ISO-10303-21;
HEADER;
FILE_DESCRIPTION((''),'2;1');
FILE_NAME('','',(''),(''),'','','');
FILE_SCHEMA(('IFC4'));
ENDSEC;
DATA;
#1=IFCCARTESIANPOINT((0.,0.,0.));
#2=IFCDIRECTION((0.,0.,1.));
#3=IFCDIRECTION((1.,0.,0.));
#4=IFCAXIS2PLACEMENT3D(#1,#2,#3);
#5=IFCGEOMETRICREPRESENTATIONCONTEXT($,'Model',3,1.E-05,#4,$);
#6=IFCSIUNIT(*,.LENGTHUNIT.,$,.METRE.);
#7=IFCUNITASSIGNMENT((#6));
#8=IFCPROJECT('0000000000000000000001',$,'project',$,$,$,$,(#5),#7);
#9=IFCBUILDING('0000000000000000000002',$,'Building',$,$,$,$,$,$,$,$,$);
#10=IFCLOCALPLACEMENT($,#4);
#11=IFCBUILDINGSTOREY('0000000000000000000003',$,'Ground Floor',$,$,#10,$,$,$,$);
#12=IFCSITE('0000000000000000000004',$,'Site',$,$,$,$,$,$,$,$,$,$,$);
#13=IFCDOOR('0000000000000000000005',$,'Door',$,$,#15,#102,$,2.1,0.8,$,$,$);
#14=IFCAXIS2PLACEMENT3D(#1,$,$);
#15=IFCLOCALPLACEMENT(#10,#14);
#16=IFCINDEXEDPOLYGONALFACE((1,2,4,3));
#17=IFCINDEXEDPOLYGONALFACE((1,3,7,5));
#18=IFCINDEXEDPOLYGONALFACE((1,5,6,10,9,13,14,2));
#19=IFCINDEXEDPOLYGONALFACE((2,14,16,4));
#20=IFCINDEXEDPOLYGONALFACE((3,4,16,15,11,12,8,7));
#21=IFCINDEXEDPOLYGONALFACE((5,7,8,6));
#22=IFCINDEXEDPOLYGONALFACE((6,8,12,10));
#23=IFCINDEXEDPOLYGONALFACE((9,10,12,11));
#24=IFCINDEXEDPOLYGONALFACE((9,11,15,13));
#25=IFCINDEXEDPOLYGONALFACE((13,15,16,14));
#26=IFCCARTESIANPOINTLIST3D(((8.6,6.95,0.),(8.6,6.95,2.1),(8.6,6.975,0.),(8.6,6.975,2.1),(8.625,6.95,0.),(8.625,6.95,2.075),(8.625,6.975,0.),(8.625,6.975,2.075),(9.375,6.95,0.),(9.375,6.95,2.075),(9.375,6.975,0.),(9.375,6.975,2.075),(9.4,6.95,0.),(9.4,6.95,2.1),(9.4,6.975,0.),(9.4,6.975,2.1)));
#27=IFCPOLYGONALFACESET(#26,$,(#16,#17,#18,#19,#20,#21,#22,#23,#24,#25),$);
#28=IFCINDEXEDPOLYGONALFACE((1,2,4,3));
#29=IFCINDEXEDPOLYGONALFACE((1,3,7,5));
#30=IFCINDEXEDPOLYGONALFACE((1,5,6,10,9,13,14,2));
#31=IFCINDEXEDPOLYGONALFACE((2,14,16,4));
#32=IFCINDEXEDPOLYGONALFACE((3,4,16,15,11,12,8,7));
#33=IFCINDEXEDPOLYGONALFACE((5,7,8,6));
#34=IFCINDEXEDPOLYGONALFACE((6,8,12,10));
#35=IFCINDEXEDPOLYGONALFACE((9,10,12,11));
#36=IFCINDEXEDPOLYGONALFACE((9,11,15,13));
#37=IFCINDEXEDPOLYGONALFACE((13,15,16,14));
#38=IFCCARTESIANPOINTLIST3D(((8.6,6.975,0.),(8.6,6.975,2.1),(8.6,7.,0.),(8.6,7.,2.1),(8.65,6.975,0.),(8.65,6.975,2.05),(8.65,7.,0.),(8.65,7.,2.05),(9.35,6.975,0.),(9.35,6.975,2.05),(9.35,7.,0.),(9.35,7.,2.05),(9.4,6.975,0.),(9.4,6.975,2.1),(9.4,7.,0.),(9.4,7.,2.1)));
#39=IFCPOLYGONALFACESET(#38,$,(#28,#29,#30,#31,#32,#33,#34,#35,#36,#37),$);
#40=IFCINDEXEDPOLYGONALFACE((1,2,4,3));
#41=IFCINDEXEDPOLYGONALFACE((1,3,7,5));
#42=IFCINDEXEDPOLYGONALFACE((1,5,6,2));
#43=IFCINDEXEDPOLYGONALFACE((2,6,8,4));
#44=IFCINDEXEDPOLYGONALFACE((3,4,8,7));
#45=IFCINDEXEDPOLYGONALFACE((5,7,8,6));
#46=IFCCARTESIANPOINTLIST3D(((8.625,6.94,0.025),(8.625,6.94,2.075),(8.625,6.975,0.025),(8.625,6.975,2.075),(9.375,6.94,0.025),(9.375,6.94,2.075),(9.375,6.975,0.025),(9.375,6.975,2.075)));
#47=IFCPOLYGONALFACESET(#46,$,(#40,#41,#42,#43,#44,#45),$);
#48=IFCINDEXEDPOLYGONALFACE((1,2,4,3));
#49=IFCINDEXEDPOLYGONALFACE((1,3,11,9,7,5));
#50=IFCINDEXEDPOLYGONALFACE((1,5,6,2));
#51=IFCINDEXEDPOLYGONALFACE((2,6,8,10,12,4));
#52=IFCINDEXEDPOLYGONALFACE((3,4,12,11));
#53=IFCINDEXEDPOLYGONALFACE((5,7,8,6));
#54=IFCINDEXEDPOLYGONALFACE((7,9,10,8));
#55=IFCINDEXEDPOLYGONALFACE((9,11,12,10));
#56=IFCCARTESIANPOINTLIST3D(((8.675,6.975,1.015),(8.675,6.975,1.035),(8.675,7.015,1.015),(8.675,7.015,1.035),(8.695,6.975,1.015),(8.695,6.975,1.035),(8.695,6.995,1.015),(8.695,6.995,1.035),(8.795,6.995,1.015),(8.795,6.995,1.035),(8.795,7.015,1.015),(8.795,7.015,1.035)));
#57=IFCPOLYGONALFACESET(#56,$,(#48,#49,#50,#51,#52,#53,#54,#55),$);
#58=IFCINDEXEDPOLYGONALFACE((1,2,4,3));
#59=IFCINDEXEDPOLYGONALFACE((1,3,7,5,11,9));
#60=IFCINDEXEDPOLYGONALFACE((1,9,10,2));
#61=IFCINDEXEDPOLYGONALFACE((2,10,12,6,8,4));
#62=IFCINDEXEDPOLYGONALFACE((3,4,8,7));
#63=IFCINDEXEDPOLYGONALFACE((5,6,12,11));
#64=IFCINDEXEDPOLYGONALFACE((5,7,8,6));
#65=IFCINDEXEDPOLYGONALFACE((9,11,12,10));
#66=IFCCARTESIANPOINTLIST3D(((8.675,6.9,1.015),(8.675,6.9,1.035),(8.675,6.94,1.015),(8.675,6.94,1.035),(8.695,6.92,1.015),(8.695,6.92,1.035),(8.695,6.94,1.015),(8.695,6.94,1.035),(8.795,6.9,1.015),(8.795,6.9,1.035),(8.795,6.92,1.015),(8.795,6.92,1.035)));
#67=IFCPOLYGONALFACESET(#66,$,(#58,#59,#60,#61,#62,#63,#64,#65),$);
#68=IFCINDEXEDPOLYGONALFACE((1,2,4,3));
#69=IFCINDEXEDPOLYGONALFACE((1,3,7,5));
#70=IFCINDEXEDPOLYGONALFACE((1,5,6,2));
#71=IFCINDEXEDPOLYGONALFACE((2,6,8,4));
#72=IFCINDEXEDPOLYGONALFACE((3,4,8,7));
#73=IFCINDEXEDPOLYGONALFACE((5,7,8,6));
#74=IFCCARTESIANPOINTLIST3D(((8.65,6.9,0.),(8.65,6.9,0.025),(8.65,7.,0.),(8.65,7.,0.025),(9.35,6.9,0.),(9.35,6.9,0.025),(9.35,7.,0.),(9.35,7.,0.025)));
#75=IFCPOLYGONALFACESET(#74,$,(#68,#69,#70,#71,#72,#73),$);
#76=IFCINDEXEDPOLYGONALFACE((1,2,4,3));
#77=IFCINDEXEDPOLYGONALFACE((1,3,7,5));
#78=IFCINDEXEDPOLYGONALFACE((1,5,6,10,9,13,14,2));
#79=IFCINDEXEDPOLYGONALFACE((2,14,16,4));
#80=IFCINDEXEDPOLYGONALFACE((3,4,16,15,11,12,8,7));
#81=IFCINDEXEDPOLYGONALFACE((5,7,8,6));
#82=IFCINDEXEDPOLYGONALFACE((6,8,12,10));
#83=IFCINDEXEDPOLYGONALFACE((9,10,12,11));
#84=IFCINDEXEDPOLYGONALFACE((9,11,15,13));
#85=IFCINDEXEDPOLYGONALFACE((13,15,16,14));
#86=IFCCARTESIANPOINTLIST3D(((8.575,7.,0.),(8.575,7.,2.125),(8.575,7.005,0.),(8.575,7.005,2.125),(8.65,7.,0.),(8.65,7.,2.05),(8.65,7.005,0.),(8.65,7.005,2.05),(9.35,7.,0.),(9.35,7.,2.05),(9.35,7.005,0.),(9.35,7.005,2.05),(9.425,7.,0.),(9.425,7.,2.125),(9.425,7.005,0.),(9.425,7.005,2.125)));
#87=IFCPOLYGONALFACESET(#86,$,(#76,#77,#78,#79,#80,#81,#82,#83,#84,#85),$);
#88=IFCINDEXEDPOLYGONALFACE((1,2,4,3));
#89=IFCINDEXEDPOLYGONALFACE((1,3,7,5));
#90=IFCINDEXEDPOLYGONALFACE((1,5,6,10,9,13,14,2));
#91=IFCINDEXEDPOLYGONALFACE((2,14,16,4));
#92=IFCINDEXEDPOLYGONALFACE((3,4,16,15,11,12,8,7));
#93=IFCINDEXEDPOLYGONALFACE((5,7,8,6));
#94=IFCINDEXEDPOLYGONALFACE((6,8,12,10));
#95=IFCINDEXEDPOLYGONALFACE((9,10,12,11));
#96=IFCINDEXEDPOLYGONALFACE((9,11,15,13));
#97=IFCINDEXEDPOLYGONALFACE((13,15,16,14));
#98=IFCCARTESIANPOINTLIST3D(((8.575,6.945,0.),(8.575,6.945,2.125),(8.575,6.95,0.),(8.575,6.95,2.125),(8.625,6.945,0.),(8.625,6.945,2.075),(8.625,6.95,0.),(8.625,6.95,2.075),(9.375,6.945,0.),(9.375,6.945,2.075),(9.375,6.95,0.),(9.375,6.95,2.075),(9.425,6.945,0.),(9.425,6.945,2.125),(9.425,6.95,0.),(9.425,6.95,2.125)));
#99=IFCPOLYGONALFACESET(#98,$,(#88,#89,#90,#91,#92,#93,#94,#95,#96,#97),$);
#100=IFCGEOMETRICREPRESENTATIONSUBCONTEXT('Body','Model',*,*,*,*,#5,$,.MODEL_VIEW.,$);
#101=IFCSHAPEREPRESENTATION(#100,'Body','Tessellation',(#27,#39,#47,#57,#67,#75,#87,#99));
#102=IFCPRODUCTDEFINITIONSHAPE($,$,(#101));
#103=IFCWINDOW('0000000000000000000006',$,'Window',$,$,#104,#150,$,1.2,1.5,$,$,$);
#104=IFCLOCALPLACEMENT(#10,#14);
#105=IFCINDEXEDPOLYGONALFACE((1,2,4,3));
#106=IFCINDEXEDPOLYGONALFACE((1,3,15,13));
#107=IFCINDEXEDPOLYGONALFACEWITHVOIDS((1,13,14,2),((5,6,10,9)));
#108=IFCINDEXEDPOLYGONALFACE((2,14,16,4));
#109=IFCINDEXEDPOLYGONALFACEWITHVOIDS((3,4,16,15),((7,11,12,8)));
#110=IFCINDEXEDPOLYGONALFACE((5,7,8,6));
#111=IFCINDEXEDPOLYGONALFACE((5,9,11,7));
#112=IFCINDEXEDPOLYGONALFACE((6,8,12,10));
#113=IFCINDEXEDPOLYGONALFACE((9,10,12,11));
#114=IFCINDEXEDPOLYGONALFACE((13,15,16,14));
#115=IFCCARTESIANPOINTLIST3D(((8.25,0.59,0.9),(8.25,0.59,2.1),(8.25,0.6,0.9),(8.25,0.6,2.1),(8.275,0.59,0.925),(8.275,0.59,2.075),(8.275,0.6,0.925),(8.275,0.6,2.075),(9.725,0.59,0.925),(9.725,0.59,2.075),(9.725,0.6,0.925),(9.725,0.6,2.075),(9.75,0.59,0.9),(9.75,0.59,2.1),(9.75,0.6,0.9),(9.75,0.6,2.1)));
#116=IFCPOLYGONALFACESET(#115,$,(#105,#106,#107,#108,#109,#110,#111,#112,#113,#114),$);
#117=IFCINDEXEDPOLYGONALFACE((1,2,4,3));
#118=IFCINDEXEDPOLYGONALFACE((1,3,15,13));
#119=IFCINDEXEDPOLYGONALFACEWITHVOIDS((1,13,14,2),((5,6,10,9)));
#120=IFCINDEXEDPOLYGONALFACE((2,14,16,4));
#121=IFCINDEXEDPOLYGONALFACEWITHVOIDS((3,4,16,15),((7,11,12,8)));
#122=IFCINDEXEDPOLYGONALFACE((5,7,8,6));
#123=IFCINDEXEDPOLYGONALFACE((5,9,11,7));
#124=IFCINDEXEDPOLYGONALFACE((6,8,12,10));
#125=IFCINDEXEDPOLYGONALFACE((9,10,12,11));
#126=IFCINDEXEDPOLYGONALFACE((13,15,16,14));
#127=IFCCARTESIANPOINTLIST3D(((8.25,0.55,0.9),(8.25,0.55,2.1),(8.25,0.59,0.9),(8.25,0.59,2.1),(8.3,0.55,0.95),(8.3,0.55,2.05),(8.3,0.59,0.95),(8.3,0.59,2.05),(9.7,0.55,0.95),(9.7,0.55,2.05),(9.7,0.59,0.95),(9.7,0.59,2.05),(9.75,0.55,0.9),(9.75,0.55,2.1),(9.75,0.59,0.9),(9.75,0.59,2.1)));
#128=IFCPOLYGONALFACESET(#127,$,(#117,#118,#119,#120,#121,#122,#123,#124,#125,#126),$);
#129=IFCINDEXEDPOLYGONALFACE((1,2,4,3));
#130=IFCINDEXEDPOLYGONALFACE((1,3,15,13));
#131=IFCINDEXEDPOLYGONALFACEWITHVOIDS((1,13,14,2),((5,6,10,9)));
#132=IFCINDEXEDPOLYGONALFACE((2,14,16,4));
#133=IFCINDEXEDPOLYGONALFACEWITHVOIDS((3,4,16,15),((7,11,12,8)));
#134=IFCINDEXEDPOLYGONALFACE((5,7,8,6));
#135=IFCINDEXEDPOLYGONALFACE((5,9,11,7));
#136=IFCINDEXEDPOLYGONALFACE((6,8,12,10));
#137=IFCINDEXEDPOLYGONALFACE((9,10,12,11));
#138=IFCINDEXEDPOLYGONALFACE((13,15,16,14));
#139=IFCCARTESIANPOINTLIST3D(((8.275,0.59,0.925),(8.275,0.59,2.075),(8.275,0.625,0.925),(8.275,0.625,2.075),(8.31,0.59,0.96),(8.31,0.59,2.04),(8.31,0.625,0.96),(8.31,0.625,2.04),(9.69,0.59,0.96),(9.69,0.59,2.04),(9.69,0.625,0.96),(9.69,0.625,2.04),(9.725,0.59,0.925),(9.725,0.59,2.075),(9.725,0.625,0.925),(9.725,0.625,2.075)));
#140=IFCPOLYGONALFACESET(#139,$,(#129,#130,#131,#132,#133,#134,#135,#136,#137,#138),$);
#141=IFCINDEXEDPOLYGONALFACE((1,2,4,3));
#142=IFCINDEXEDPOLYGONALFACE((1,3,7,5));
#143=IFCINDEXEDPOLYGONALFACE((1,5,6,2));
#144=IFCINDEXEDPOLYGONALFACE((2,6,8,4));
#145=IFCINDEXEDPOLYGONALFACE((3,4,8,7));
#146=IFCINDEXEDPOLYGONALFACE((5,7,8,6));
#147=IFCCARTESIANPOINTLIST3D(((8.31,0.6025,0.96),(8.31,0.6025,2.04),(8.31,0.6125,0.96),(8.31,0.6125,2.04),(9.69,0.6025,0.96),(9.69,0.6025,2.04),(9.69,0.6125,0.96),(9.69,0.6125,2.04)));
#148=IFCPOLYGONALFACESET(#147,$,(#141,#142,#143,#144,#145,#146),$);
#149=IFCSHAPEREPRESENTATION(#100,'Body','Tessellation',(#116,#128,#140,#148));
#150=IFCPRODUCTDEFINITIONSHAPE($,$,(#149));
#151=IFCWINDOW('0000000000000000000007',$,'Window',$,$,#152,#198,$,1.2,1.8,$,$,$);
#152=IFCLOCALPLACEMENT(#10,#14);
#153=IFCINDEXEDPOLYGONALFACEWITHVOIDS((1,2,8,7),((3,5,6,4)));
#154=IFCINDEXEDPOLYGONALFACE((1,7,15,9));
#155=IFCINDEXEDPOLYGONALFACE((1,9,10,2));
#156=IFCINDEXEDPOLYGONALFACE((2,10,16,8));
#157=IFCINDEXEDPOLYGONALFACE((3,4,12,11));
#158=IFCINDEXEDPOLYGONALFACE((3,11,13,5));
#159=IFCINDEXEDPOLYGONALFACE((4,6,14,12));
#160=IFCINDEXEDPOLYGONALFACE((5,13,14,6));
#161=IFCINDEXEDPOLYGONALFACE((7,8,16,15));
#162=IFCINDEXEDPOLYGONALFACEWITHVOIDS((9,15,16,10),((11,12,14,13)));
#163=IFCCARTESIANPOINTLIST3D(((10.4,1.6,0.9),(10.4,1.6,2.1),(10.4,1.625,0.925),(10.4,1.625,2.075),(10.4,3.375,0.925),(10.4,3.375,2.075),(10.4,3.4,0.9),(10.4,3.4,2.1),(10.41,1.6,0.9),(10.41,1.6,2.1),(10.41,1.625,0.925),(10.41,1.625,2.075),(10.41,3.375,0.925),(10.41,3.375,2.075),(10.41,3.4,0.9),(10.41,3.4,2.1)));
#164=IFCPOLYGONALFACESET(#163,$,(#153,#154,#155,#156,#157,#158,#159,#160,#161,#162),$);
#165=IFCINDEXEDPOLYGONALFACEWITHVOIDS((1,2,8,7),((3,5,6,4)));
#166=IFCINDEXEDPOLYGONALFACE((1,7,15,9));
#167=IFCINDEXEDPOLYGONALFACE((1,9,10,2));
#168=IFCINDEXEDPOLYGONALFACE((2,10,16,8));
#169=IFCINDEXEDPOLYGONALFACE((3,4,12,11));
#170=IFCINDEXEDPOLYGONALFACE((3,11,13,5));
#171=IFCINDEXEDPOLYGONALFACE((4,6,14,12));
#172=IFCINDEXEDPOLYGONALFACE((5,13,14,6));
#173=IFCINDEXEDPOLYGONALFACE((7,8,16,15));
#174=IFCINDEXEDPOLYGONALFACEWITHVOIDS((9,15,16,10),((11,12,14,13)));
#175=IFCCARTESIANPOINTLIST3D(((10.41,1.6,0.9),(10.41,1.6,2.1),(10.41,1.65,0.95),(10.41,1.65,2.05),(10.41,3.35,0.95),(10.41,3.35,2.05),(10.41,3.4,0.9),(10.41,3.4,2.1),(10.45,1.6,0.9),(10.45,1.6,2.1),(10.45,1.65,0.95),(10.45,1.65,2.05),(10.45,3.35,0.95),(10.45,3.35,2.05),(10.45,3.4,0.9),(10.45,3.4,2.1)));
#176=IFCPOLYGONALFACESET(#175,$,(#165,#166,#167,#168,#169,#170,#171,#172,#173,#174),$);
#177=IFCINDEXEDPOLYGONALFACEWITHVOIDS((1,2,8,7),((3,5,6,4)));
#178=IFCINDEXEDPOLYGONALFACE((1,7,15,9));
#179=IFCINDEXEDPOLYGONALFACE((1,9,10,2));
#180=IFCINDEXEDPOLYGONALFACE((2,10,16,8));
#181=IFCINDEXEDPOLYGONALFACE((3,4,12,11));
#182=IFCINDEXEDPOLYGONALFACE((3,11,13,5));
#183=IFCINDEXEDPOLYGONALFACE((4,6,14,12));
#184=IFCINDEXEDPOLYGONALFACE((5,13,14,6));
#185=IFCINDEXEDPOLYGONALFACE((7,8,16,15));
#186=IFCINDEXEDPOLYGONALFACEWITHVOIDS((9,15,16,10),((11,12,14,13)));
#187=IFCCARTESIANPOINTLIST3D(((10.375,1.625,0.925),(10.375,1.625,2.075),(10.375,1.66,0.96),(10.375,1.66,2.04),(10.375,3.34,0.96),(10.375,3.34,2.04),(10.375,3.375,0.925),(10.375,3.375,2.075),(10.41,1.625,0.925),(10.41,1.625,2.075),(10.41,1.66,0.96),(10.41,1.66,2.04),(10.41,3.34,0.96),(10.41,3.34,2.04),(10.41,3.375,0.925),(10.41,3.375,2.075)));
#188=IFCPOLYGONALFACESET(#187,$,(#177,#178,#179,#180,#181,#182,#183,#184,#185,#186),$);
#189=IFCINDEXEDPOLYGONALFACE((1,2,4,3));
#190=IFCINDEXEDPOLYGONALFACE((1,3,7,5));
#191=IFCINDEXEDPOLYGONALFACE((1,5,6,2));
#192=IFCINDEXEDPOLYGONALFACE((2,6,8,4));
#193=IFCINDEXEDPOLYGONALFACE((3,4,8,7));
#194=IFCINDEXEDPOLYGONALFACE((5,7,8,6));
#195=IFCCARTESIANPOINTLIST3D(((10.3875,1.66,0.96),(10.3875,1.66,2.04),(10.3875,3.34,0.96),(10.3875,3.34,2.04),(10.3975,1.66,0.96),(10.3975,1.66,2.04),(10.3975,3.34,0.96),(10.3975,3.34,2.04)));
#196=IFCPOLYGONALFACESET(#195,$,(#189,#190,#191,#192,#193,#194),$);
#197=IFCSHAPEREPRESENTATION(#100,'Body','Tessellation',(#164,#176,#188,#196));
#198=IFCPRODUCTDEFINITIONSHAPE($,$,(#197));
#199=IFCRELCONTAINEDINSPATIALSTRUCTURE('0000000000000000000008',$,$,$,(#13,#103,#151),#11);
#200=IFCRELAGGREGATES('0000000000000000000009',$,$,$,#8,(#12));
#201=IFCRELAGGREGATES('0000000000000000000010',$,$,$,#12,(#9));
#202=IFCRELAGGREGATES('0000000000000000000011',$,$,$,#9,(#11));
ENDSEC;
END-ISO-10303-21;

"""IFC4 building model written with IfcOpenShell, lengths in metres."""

from ifc_helpers import new_model, si_unit, frame, origin_with_axes, place, context, subcontext, project, spatial, line, indexed_curve, outline, extrude, element, save


model = new_model("IFC4")

# Units and contexts
model_context = context("Model", 3, precision=1e-05, world=origin_with_axes())
body_context = subcontext(model_context, "Body", "Model", "MODEL_VIEW")
ifc_project = project(units=[si_unit("LENGTHUNIT", "METRE")], contexts=[model_context])

# Site, building, storey
site = spatial("IfcSite", under=ifc_project, Name="Site")
building = spatial("IfcBuilding", under=site, Name="Building")
storey_placement = place(None, origin_with_axes())
storey = spatial("IfcBuildingStorey", under=building, at=storey_placement, Name="Ground Floor")

# Door
door_1_placement = place(storey_placement, frame((9.4, 7.0, 0.0), z_axis=(0.0, 0.0, 1.0), x_axis=(-1.0, 0.0, 0.0)))
element("IfcDoor", 1, at=door_1_placement, inside=storey, Name="Door", OverallHeight=2.1, OverallWidth=0.8, context=body_context, shape_type="SweptSolid", body=[
    extrude(outline(indexed_curve([(0.0, 0.0), (0.0, 2.1), (0.8, 2.1), (0.8, 0.0), (0.775, 0.0), (0.775, 2.075), (0.025, 2.075), (0.025, 0.0)], segments=[line(1, 2, 3, 4, 5, 6, 7, 8, 1)])), frame((0.0, 0.025, 0.0), z_axis=(0.0, -1.0, 0.0), x_axis=(1.0, 0.0, 0.0)), (0.0, 0.0, -1.0), 0.025),
    extrude(outline(indexed_curve([(0.0, 0.0), (0.0, 2.1), (0.8, 2.1), (0.8, 0.0), (0.75, 0.0), (0.75, 2.05), (0.05, 2.05), (0.05, 0.0)], segments=[line(1, 2, 3, 4, 5, 6, 7, 8, 1)])), frame((0.0, 0.0, 0.0), z_axis=(0.0, -1.0, 0.0), x_axis=(1.0, 0.0, 0.0)), (0.0, 0.0, -1.0), 0.025),
    extrude(outline(indexed_curve([(0.0, 0.0), (0.75, 0.0), (0.75, 0.035), (0.0, 0.035)], segments=[line(1, 2, 3, 4, 1)])), frame((0.025, 0.025, 0.025), z_axis=(0.0, 0.0, 1.0), x_axis=(1.0, 0.0, 0.0)), (0.0, 0.0, 1.0), 2.05),
    extrude(outline(indexed_curve([(0.0, 0.0), (0.0, -0.04), (-0.12, -0.04), (-0.12, -0.02), (-0.02, -0.02), (-0.02, 0.0)], segments=[line(1, 2, 3, 4, 5, 6, 1)])), frame((0.725, 0.025, 1.015), z_axis=(0.0, 0.0, 1.0), x_axis=(1.0, 0.0, 0.0)), (0.0, 0.0, 1.0), 0.02),
    extrude(outline(indexed_curve([(0.0, 0.0), (0.0, 0.04), (-0.12, 0.04), (-0.12, 0.02), (-0.02, 0.02), (-0.02, 0.0)], segments=[line(1, 2, 3, 4, 5, 6, 1)])), frame((0.725, 0.06, 1.015), z_axis=(0.0, 0.0, 1.0), x_axis=(1.0, 0.0, 0.0)), (0.0, 0.0, 1.0), 0.02),
    extrude(outline(indexed_curve([(0.0, 0.0), (0.7, 0.0), (0.7, 0.1), (0.0, 0.1)], segments=[line(1, 2, 3, 4, 1)])), frame((0.05, 0.0, 0.0), z_axis=(0.0, 0.0, 1.0), x_axis=(1.0, 0.0, 0.0)), (0.0, 0.0, 1.0), 0.025),
    extrude(outline(indexed_curve([(0.0, 0.0), (0.0, 2.125), (0.85, 2.125), (0.85, 0.0), (0.775, 0.0), (0.775, 2.05), (0.075, 2.05), (0.075, 0.0)], segments=[line(1, 2, 3, 4, 5, 6, 7, 8, 1)])), frame((-0.025, -0.005, 0.0), z_axis=(0.0, -1.0, 0.0), x_axis=(1.0, 0.0, 0.0)), (0.0, 0.0, -1.0), 0.005),
    extrude(outline(indexed_curve([(0.0, 0.0), (0.0, 2.125), (0.85, 2.125), (0.85, 0.0), (0.8, 0.0), (0.8, 2.075), (0.05, 2.075), (0.05, 0.0)], segments=[line(1, 2, 3, 4, 5, 6, 7, 8, 1)])), frame((-0.025, 0.05, 0.0), z_axis=(0.0, -1.0, 0.0), x_axis=(1.0, 0.0, 0.0)), (0.0, 0.0, -1.0), 0.005),
])

# Windows
window_1_placement = place(storey_placement, frame((8.25, 0.5, 0.9), z_axis=(0.0, 0.0, 1.0), x_axis=(1.0, 0.0, 0.0)))
element("IfcWindow", 2, at=window_1_placement, inside=storey, Name="Window", OverallHeight=1.2, OverallWidth=1.5, context=body_context, shape_type="SweptSolid", body=[
    extrude(outline(indexed_curve([(0.0, 0.0), (1.5, 0.0), (1.5, 1.2), (0.0, 1.2)], segments=[line(1, 2, 3, 4, 1)]), holes=[indexed_curve([(0.025, 0.025), (1.475, 0.025), (1.475, 1.175), (0.025, 1.175)], segments=[line(1, 2, 3, 4, 1)])]), frame((0.0, 0.09, 0.0), z_axis=(0.0, -1.0, 0.0), x_axis=(1.0, 0.0, 0.0)), (0.0, 0.0, -1.0), 0.01),
    extrude(outline(indexed_curve([(0.0, 0.0), (1.5, 0.0), (1.5, 1.2), (0.0, 1.2)], segments=[line(1, 2, 3, 4, 1)]), holes=[indexed_curve([(0.05, 0.05), (1.45, 0.05), (1.45, 1.15), (0.05, 1.15)], segments=[line(1, 2, 3, 4, 1)])]), frame((0.0, 0.05, 0.0), z_axis=(0.0, -1.0, 0.0), x_axis=(1.0, 0.0, 0.0)), (0.0, 0.0, -1.0), 0.04),
    extrude(outline(indexed_curve([(0.0, 0.0), (1.45, 0.0), (1.45, 1.15), (0.0, 1.15)], segments=[line(1, 2, 3, 4, 1)]), holes=[indexed_curve([(0.035, 0.035), (1.415, 0.035), (1.415, 1.115), (0.035, 1.115)], segments=[line(1, 2, 3, 4, 1)])]), frame((0.025, 0.09, 0.025), z_axis=(0.0, -1.0, 0.0), x_axis=(1.0, 0.0, 0.0)), (0.0, 0.0, -1.0), 0.035),
    extrude(outline(indexed_curve([(0.035, 0.035), (1.415, 0.035), (1.415, 1.115), (0.035, 1.115)], segments=[line(1, 2, 3, 4, 1)])), frame((0.025, 0.1025, 0.025), z_axis=(0.0, -1.0, 0.0), x_axis=(1.0, 0.0, 0.0)), (0.0, 0.0, -1.0), 0.01),
])
window_2_placement = place(storey_placement, frame((10.5, 1.6, 0.9), z_axis=(0.0, 0.0, 1.0), x_axis=(0.0, 1.0, 0.0)))
element("IfcWindow", 3, at=window_2_placement, inside=storey, Name="Window", OverallHeight=1.2, OverallWidth=1.8, context=body_context, shape_type="SweptSolid", body=[
    extrude(outline(indexed_curve([(0.0, 0.0), (1.8, 0.0), (1.8, 1.2), (0.0, 1.2)], segments=[line(1, 2, 3, 4, 1)]), holes=[indexed_curve([(0.025, 0.025), (1.775, 0.025), (1.775, 1.175), (0.025, 1.175)], segments=[line(1, 2, 3, 4, 1)])]), frame((0.0, 0.09, 0.0), z_axis=(0.0, -1.0, 0.0), x_axis=(1.0, 0.0, 0.0)), (0.0, 0.0, -1.0), 0.01),
    extrude(outline(indexed_curve([(0.0, 0.0), (1.8, 0.0), (1.8, 1.2), (0.0, 1.2)], segments=[line(1, 2, 3, 4, 1)]), holes=[indexed_curve([(0.05, 0.05), (1.75, 0.05), (1.75, 1.15), (0.05, 1.15)], segments=[line(1, 2, 3, 4, 1)])]), frame((0.0, 0.05, 0.0), z_axis=(0.0, -1.0, 0.0), x_axis=(1.0, 0.0, 0.0)), (0.0, 0.0, -1.0), 0.04),
    extrude(outline(indexed_curve([(0.0, 0.0), (1.75, 0.0), (1.75, 1.15), (0.0, 1.15)], segments=[line(1, 2, 3, 4, 1)]), holes=[indexed_curve([(0.035, 0.035), (1.715, 0.035), (1.715, 1.115), (0.035, 1.115)], segments=[line(1, 2, 3, 4, 1)])]), frame((0.025, 0.09, 0.025), z_axis=(0.0, -1.0, 0.0), x_axis=(1.0, 0.0, 0.0)), (0.0, 0.0, -1.0), 0.035),
    extrude(outline(indexed_curve([(0.035, 0.035), (1.715, 0.035), (1.715, 1.115), (0.035, 1.115)], segments=[line(1, 2, 3, 4, 1)])), frame((0.025, 0.1025, 0.025), z_axis=(0.0, -1.0, 0.0), x_axis=(1.0, 0.0, 0.0)), (0.0, 0.0, -1.0), 0.01),
])

save(model, "model.ifc")
